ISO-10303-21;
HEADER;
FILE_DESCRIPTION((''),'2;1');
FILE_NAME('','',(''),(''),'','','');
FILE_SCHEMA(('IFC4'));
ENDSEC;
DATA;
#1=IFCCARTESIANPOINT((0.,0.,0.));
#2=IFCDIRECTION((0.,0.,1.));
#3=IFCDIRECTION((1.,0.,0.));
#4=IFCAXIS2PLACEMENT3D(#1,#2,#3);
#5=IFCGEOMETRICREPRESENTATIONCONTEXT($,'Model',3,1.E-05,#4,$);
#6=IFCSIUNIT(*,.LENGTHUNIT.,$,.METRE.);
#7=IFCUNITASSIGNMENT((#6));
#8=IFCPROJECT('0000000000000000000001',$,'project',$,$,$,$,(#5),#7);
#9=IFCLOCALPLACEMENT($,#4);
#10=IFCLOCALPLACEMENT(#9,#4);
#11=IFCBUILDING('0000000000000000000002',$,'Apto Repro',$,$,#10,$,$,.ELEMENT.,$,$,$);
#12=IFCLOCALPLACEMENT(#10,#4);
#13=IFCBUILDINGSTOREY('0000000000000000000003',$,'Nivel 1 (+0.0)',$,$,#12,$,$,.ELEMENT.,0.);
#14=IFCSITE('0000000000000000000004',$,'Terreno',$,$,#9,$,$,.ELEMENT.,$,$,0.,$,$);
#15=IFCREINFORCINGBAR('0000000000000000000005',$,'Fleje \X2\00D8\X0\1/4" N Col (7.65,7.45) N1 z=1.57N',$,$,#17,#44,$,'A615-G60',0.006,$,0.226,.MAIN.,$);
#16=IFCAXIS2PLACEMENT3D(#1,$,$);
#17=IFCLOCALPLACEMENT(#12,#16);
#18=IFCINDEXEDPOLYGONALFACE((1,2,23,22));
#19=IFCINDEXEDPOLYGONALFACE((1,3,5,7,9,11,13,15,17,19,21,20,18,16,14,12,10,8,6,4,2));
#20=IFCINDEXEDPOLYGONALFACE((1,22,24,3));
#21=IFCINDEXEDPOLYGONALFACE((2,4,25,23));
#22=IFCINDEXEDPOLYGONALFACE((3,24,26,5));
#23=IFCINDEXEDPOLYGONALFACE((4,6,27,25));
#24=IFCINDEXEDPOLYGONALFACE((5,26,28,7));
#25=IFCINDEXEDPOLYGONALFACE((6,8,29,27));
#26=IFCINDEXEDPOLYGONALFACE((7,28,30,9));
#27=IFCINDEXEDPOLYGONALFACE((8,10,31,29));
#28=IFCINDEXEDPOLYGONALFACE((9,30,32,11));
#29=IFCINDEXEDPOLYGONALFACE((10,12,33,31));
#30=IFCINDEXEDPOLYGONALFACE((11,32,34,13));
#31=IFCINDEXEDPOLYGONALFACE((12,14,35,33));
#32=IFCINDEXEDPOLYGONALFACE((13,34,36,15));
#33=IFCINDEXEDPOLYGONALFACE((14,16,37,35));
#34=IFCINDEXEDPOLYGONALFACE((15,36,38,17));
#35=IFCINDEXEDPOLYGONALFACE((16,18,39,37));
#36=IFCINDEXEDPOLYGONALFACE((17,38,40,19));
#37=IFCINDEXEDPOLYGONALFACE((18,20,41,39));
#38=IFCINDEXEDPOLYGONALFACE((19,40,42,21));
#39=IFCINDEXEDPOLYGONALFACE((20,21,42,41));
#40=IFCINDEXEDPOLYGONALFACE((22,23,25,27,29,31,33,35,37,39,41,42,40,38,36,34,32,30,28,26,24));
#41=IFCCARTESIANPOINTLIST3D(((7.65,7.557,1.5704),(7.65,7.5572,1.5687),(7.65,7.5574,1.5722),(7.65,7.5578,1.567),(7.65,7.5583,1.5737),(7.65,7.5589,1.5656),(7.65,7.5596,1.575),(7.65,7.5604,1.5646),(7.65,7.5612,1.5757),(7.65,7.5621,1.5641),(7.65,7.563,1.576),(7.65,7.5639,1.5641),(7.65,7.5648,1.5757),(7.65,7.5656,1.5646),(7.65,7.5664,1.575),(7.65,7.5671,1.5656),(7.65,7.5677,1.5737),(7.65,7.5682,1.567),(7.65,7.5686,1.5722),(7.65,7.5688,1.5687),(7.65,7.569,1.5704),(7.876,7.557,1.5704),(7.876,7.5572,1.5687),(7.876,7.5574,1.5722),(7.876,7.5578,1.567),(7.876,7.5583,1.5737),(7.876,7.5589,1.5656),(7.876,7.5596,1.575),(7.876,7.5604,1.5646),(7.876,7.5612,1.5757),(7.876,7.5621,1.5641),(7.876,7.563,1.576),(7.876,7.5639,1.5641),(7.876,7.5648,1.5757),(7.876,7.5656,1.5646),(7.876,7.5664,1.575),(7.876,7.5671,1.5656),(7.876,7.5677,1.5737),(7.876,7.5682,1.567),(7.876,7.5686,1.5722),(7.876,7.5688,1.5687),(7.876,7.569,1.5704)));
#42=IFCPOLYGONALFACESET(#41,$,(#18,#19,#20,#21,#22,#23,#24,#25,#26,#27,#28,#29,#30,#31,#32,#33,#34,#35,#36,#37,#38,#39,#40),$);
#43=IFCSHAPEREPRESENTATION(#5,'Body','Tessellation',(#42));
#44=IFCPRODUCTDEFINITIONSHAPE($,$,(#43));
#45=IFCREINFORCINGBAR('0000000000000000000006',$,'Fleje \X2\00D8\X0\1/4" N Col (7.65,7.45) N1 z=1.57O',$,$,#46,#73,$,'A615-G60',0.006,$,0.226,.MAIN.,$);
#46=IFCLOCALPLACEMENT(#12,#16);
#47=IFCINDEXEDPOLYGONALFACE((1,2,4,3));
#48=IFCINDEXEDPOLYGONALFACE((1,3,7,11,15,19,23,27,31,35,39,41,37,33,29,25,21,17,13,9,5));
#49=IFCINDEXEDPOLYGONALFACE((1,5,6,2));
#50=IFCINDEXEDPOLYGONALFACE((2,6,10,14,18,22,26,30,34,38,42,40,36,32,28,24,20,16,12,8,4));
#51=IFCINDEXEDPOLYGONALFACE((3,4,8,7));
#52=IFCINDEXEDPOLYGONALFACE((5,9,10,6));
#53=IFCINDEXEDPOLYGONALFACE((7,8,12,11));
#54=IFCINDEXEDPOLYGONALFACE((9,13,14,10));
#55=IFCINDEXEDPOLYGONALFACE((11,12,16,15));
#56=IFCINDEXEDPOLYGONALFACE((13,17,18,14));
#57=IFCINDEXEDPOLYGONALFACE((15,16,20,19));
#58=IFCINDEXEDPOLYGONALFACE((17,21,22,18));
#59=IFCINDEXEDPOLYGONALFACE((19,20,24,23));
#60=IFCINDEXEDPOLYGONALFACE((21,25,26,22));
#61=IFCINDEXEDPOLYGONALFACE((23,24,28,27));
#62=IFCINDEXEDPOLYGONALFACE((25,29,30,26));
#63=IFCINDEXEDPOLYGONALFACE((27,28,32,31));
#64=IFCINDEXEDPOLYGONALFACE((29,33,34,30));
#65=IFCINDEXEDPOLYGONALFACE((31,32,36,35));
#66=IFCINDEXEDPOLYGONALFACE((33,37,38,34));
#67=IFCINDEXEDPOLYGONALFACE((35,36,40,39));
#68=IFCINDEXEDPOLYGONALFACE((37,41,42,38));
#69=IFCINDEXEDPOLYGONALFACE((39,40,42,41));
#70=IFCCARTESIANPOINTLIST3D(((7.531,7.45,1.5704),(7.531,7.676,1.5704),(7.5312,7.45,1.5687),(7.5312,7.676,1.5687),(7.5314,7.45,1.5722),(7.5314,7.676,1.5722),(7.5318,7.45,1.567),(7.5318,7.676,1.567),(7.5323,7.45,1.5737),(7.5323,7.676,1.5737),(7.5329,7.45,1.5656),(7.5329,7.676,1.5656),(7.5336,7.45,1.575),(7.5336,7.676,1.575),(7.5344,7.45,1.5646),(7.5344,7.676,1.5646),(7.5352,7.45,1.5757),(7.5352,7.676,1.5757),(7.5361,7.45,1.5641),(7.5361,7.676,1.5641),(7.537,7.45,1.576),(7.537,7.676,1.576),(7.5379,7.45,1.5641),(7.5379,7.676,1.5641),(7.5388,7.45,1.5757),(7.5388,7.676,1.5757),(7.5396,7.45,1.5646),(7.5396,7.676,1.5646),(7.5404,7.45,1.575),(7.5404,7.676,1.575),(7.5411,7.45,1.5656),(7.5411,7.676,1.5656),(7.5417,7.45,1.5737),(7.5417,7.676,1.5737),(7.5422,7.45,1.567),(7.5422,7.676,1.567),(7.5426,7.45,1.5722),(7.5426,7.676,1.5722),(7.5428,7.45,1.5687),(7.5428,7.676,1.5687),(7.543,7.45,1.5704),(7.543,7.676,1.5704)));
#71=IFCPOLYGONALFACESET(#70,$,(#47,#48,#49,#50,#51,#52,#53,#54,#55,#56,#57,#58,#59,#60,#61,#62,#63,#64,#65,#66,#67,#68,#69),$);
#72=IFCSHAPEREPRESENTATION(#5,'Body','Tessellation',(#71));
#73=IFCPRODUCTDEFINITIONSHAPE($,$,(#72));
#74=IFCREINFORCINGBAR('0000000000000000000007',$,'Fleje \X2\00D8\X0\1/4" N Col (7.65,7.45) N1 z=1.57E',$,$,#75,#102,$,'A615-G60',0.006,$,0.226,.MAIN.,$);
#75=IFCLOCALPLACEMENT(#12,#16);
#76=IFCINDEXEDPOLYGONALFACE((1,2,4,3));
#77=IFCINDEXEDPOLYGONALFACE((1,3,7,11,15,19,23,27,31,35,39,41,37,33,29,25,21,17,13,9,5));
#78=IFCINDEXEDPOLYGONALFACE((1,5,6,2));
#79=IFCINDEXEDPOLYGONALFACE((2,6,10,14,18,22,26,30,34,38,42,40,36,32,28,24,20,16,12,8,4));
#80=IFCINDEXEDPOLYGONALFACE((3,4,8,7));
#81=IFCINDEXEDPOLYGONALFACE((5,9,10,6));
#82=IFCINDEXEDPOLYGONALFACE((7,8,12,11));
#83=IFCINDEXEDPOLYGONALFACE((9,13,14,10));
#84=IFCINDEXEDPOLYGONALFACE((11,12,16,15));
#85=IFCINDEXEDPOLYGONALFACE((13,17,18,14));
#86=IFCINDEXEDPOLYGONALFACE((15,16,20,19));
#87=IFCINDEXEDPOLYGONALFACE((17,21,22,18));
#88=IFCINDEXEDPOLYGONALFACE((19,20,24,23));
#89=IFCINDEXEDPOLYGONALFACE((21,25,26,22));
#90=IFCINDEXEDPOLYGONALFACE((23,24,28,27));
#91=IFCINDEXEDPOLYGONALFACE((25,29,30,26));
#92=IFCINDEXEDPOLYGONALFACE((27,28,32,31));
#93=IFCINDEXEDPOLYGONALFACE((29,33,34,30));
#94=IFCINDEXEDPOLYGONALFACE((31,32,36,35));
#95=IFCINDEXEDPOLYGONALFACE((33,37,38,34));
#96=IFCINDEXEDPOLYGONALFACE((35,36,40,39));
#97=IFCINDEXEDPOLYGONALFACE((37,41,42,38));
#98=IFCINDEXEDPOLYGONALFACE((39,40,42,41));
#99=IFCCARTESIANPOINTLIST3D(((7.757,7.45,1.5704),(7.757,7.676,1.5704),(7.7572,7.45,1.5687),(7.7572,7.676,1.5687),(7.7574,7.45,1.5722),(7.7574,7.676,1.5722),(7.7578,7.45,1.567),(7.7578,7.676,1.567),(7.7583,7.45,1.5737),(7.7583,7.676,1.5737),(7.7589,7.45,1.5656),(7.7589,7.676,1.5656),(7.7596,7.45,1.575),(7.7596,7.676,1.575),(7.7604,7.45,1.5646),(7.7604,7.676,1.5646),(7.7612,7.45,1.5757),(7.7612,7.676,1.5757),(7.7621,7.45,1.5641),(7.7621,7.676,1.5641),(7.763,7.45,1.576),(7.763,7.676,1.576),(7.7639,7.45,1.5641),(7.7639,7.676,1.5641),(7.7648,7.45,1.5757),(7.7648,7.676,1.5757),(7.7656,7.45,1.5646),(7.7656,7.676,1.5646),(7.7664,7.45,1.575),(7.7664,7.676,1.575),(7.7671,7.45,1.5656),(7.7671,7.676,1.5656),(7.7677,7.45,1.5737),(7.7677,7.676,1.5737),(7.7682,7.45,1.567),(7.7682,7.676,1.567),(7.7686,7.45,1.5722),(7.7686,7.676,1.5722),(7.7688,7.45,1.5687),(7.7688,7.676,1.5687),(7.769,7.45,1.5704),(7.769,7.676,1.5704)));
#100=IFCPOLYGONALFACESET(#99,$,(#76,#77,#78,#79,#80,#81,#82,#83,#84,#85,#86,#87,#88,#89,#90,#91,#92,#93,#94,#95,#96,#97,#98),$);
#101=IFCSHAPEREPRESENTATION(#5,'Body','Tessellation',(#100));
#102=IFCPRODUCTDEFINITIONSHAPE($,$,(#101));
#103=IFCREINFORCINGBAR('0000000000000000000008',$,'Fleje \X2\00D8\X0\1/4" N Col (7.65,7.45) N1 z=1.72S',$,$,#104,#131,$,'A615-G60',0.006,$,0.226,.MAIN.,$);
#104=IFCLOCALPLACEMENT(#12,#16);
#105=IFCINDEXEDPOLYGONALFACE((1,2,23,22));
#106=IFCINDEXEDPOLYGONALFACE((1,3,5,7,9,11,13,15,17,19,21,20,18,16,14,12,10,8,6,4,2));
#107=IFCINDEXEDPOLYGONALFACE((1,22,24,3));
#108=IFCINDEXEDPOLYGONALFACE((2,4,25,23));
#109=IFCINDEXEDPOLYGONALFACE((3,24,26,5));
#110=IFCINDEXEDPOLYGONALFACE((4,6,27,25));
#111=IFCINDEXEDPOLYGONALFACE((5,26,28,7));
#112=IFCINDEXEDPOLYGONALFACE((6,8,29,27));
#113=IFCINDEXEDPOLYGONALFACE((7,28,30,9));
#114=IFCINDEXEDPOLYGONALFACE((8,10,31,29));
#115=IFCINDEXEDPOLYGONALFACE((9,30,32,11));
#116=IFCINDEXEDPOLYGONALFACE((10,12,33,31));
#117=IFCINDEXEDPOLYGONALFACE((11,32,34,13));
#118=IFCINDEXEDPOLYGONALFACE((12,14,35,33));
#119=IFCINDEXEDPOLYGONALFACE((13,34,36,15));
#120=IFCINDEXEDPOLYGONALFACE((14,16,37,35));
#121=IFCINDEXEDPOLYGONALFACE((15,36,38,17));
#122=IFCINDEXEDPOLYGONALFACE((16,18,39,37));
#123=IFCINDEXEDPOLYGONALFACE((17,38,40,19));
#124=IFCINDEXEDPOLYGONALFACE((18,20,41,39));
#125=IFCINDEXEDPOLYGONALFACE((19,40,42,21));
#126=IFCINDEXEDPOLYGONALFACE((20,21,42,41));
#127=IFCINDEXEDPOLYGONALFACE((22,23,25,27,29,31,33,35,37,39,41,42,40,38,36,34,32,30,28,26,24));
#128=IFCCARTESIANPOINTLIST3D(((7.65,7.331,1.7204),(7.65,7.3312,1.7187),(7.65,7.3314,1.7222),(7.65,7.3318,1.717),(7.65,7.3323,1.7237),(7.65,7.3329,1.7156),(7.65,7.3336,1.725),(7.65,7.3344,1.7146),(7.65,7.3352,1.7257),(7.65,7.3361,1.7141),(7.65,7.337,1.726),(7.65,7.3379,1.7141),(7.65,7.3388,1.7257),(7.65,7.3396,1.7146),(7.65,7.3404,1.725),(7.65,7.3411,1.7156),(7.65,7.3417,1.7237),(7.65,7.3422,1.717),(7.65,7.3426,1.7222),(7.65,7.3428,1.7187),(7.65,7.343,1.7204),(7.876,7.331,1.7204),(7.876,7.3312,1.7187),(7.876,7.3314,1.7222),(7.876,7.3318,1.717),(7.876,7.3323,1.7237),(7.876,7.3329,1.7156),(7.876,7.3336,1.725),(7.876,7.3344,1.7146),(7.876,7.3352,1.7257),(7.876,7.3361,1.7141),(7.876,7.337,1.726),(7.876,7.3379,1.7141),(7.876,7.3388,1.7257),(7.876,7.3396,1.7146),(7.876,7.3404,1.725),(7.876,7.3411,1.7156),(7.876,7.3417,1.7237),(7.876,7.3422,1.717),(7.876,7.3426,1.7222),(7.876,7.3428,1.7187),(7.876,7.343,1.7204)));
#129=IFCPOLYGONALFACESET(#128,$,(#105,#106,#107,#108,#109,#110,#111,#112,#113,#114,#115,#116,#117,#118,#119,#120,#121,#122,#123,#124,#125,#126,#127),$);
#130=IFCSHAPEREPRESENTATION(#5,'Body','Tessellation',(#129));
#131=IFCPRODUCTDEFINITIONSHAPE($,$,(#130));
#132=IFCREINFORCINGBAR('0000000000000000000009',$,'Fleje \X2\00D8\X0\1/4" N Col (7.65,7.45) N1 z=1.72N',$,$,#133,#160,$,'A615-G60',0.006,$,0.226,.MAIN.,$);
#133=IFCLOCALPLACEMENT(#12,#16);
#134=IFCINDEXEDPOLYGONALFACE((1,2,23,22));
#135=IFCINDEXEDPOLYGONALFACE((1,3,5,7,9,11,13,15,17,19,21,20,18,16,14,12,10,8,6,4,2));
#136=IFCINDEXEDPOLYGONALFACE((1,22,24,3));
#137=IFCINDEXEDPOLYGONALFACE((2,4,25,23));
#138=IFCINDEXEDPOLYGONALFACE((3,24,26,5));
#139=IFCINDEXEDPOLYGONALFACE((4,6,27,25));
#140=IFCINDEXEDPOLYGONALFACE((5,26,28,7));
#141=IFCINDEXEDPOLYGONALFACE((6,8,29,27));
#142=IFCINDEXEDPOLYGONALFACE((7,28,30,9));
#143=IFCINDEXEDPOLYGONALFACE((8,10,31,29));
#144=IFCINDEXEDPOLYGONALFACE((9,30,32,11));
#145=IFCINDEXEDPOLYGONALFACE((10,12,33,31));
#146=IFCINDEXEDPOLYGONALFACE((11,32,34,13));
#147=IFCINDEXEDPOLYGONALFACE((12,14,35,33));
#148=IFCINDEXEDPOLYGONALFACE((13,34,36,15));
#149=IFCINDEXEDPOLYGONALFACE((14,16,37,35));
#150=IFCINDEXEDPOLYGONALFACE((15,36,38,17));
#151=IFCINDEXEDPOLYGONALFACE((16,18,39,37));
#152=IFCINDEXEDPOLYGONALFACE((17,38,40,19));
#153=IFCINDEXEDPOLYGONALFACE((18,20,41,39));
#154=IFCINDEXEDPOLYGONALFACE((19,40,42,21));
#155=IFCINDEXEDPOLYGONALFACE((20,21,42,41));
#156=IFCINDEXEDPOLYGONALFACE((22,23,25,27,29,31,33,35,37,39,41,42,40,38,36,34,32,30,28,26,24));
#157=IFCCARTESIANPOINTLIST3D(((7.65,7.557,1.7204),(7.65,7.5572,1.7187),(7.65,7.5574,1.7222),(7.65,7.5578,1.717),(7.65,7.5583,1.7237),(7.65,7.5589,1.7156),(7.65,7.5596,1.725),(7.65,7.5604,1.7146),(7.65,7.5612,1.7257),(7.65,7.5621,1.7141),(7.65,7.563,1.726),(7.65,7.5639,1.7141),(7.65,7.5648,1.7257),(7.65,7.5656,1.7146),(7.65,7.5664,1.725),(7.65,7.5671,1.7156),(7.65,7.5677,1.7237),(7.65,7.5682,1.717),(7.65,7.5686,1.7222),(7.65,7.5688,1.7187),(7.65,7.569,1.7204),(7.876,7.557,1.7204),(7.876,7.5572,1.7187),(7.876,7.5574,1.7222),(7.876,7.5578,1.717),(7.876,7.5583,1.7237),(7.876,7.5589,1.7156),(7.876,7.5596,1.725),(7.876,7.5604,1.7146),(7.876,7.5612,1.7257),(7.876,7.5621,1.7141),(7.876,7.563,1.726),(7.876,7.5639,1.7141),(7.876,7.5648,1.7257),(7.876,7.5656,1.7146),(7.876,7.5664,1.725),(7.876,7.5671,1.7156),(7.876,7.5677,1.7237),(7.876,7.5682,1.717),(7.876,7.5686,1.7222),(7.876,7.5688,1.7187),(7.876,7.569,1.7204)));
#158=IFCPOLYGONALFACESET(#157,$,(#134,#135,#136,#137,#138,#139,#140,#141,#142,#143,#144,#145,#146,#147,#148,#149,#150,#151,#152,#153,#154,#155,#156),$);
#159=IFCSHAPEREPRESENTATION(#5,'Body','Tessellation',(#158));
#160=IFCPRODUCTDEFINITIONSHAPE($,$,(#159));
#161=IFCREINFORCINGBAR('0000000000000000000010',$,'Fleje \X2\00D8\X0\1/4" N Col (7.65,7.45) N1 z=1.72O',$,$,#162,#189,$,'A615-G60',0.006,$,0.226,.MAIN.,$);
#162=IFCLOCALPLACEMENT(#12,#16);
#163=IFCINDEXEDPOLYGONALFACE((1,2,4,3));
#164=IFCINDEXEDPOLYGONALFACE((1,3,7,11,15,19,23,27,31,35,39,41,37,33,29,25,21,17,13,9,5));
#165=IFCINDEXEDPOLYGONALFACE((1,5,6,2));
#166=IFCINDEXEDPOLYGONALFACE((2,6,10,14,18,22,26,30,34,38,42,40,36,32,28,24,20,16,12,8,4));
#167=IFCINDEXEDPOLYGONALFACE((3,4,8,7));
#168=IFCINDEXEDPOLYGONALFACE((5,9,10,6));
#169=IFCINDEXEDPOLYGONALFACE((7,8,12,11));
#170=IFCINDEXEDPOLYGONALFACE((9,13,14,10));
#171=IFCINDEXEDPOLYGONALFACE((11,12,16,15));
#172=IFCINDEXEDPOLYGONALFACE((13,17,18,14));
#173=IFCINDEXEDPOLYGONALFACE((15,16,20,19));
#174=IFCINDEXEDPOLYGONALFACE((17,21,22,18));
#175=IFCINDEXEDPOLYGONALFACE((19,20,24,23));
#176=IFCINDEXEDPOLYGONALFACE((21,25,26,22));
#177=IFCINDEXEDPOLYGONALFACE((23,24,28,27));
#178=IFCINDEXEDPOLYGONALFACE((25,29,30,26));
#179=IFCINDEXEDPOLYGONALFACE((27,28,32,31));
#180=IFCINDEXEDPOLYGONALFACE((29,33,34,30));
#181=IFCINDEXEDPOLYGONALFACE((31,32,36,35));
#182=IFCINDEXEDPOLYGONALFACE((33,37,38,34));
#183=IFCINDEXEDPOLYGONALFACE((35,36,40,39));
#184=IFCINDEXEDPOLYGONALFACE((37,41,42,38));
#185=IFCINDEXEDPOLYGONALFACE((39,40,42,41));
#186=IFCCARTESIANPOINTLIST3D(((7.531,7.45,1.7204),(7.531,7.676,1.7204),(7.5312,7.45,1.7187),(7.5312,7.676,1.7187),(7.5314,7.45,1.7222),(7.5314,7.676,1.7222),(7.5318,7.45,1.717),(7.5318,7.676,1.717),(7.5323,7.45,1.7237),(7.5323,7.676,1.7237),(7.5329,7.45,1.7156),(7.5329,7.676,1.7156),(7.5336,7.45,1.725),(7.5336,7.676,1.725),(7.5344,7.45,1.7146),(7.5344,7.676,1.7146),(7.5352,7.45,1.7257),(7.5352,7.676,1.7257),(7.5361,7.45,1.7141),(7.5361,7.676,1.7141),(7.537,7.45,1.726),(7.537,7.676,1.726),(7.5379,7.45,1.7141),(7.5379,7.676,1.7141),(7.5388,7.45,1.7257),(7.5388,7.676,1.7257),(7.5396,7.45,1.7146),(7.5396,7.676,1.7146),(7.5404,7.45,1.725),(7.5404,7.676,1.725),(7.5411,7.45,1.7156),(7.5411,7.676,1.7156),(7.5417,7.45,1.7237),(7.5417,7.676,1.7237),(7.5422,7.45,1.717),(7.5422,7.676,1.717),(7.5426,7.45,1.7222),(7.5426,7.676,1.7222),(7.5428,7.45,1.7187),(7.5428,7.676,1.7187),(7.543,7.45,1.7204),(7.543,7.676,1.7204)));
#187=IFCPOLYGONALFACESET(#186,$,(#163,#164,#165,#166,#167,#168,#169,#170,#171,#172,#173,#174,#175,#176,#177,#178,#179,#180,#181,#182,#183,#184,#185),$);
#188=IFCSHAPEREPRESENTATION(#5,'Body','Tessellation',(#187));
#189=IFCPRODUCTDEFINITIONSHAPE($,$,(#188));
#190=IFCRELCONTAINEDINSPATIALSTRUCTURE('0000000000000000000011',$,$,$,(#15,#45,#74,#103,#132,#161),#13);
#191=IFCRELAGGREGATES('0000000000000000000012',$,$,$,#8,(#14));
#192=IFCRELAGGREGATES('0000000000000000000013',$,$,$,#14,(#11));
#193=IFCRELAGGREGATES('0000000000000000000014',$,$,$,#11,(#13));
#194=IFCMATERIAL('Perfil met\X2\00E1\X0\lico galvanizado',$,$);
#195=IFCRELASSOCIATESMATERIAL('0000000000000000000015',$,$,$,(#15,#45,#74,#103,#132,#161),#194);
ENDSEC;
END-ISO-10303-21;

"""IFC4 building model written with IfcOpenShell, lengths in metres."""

from ifc_helpers import new_model, si_unit, frame, origin_with_axes, origin_2d_with_axis, place, context, project, spatial, circle, extrude, material, element, save


model = new_model("IFC4")

# Units and contexts
model_context = context("Model", 3, precision=1e-05, world=origin_with_axes())
ifc_project = project(units=[si_unit("LENGTHUNIT", "METRE")], contexts=[model_context])

# Site, building, storey
site_placement = place(None, origin_with_axes())
site = spatial("IfcSite", under=ifc_project, at=site_placement, Name="Terreno", CompositionType="ELEMENT", RefElevation=0.0)
building_placement = place(site_placement, origin_with_axes())
building = spatial("IfcBuilding", under=site, at=building_placement, Name="Apto Repro", CompositionType="ELEMENT")
storey_placement = place(building_placement, origin_with_axes())
storey = spatial("IfcBuildingStorey", under=building, at=storey_placement, Name="Nivel 1 (+0.0)", CompositionType="ELEMENT", Elevation=0.0)

# Reinforcing bars
ifc_material = material(Name="Perfil metálico galvanizado")
reinforcing_bar_1_placement = place(storey_placement, origin_with_axes())
element("IfcReinforcingBar", 1, at=reinforcing_bar_1_placement, inside=storey, material=ifc_material, Name="Fleje Ø1/4\" N Col (7.65,7.45) N1 z=1.57N", SteelGrade="A615-G60", BarLength=0.226, NominalDiameter=0.006, PredefinedType="MAIN", context=model_context, shape_type="SweptSolid", body=[
    extrude(circle(Radius=0.006, at=origin_2d_with_axis()), frame((7.65, 7.563, 1.57), z_axis=(1.0, 0.0, 0.0), x_axis=(0.0, 0.0, 1.0)), (0.0, 0.0, 1.0), 0.226),
])
reinforcing_bar_2_placement = place(storey_placement, origin_with_axes())
element("IfcReinforcingBar", 2, at=reinforcing_bar_2_placement, inside=storey, material=ifc_material, Name="Fleje Ø1/4\" N Col (7.65,7.45) N1 z=1.57O", SteelGrade="A615-G60", BarLength=0.226, NominalDiameter=0.006, PredefinedType="MAIN", context=model_context, shape_type="SweptSolid", body=[
    extrude(circle(Radius=0.006, at=origin_2d_with_axis()), frame((7.537, 7.45, 1.57), z_axis=(0.0, 1.0, 0.0), x_axis=(0.0, 0.0, 1.0)), (0.0, 0.0, 1.0), 0.226),
])
reinforcing_bar_3_placement = place(storey_placement, origin_with_axes())
element("IfcReinforcingBar", 3, at=reinforcing_bar_3_placement, inside=storey, material=ifc_material, Name="Fleje Ø1/4\" N Col (7.65,7.45) N1 z=1.57E", SteelGrade="A615-G60", BarLength=0.226, NominalDiameter=0.006, PredefinedType="MAIN", context=model_context, shape_type="SweptSolid", body=[
    extrude(circle(Radius=0.006, at=origin_2d_with_axis()), frame((7.763, 7.45, 1.57), z_axis=(0.0, 1.0, 0.0), x_axis=(0.0, 0.0, 1.0)), (0.0, 0.0, 1.0), 0.226),
])
reinforcing_bar_4_placement = place(storey_placement, origin_with_axes())
element("IfcReinforcingBar", 4, at=reinforcing_bar_4_placement, inside=storey, material=ifc_material, Name="Fleje Ø1/4\" N Col (7.65,7.45) N1 z=1.72S", SteelGrade="A615-G60", BarLength=0.226, NominalDiameter=0.006, PredefinedType="MAIN", context=model_context, shape_type="SweptSolid", body=[
    extrude(circle(Radius=0.006, at=origin_2d_with_axis()), frame((7.65, 7.337, 1.72), z_axis=(1.0, 0.0, 0.0), x_axis=(0.0, 0.0, 1.0)), (0.0, 0.0, 1.0), 0.226),
])
reinforcing_bar_5_placement = place(storey_placement, origin_with_axes())
element("IfcReinforcingBar", 5, at=reinforcing_bar_5_placement, inside=storey, material=ifc_material, Name="Fleje Ø1/4\" N Col (7.65,7.45) N1 z=1.72N", SteelGrade="A615-G60", BarLength=0.226, NominalDiameter=0.006, PredefinedType="MAIN", context=model_context, shape_type="SweptSolid", body=[
    extrude(circle(Radius=0.006, at=origin_2d_with_axis()), frame((7.65, 7.563, 1.72), z_axis=(1.0, 0.0, 0.0), x_axis=(0.0, 0.0, 1.0)), (0.0, 0.0, 1.0), 0.226),
])
reinforcing_bar_6_placement = place(storey_placement, origin_with_axes())
element("IfcReinforcingBar", 6, at=reinforcing_bar_6_placement, inside=storey, material=ifc_material, Name="Fleje Ø1/4\" N Col (7.65,7.45) N1 z=1.72O", SteelGrade="A615-G60", BarLength=0.226, NominalDiameter=0.006, PredefinedType="MAIN", context=model_context, shape_type="SweptSolid", body=[
    extrude(circle(Radius=0.006, at=origin_2d_with_axis()), frame((7.537, 7.45, 1.72), z_axis=(0.0, 1.0, 0.0), x_axis=(0.0, 0.0, 1.0)), (0.0, 0.0, 1.0), 0.226),
])

save(model, "model.ifc")
